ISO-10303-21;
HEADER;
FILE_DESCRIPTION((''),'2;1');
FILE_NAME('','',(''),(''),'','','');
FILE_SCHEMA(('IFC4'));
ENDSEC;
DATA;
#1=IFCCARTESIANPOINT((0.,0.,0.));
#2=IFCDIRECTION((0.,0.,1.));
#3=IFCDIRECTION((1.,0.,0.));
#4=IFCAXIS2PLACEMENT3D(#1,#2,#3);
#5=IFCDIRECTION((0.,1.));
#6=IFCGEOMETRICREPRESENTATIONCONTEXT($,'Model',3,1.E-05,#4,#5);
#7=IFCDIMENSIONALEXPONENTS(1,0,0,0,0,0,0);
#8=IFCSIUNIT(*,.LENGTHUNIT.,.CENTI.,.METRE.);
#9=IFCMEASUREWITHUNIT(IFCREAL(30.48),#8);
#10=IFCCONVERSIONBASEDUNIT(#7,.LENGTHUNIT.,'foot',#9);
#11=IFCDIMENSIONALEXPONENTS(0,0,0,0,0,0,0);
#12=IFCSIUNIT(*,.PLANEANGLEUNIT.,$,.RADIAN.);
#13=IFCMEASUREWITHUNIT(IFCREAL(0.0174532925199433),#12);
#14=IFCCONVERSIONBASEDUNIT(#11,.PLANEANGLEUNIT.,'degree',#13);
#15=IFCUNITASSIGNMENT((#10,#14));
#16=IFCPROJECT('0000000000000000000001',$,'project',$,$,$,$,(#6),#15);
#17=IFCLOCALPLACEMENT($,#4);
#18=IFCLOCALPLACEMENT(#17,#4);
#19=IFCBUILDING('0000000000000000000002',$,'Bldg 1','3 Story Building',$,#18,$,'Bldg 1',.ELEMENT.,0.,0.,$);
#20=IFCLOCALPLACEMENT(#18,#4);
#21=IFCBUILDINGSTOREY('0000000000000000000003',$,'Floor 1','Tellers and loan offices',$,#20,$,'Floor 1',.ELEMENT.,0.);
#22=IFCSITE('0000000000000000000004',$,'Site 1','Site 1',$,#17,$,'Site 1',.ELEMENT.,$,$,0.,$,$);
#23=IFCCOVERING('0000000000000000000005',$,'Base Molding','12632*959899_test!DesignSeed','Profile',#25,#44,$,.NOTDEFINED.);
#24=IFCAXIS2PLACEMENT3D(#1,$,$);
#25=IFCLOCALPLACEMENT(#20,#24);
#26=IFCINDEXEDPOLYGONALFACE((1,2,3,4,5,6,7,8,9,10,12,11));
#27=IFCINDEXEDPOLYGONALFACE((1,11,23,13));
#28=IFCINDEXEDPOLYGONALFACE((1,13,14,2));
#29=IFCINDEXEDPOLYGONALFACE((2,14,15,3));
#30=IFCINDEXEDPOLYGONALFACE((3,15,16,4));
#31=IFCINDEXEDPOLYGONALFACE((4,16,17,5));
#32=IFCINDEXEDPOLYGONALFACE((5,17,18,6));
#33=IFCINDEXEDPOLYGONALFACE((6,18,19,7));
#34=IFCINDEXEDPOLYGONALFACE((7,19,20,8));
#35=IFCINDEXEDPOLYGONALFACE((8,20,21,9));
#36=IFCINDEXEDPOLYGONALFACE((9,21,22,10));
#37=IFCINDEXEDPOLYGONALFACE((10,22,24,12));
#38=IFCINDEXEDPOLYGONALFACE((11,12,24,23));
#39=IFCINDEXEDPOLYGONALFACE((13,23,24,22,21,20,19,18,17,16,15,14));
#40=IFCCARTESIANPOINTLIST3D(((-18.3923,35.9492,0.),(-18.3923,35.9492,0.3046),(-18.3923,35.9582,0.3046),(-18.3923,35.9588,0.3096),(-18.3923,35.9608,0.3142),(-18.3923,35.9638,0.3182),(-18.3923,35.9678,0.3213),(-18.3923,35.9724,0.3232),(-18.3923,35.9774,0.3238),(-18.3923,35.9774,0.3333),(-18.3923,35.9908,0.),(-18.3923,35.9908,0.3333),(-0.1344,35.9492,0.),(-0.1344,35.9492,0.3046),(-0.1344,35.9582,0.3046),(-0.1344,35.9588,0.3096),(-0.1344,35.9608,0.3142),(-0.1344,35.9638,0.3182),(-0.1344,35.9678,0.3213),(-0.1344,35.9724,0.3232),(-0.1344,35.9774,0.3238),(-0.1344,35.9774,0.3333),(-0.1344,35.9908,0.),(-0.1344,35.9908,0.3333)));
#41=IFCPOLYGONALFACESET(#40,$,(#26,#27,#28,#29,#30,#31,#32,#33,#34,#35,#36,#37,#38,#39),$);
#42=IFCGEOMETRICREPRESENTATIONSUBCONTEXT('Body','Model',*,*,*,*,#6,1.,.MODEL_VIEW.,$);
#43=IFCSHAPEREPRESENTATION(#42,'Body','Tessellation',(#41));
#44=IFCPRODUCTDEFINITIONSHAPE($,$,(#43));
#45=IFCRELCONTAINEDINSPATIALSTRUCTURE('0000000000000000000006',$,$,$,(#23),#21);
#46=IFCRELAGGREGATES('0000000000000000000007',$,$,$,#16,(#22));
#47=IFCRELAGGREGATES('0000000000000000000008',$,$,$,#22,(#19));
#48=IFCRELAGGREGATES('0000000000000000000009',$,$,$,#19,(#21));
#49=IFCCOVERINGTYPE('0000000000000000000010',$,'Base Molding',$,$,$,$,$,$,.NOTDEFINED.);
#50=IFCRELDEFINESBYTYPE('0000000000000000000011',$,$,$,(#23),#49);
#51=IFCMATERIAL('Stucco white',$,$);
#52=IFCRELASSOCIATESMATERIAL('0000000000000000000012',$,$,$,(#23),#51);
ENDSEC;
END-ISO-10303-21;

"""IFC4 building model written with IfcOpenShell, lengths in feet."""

from ifc_helpers import new_model, entity, si_unit, converted_unit, direction, frame, origin_with_axes, place, context, subcontext, project, spatial, line, arc, indexed_curve, outline, extrude, material, type_object, element, save


model = new_model("IFC4")

# Units and contexts
model_context = context("Model", 3, precision=1e-05, world=origin_with_axes(), true_north=direction((0.0, 1.0)))
body_context = subcontext(model_context, "Body", "Model", "MODEL_VIEW", scale=1.0)
ifc_project = project(units=[converted_unit("LENGTHUNIT", "foot", entity("IfcReal", 30.48), si_unit("LENGTHUNIT", "METRE", prefix="CENTI"), dimensions=[1, 0, 0, 0, 0, 0, 0]), converted_unit("PLANEANGLEUNIT", "degree", entity("IfcReal", 0.0174532925199433), si_unit("PLANEANGLEUNIT", "RADIAN"), dimensions=[0, 0, 0, 0, 0, 0, 0])], contexts=[model_context])

# Site, building, storey
site_placement = place(None, origin_with_axes())
site = spatial("IfcSite", under=ifc_project, at=site_placement, Name="Site 1", Description="Site 1", LongName="Site 1", CompositionType="ELEMENT", RefElevation=0.0)
building_placement = place(site_placement, origin_with_axes())
building = spatial("IfcBuilding", under=site, at=building_placement, Name="Bldg 1", Description="3 Story Building", LongName="Bldg 1", CompositionType="ELEMENT", ElevationOfRefHeight=0.0, ElevationOfTerrain=0.0)
storey_placement = place(building_placement, origin_with_axes())
storey = spatial("IfcBuildingStorey", under=building, at=storey_placement, Name="Floor 1", Description="Tellers and loan offices", LongName="Floor 1", CompositionType="ELEMENT", Elevation=0.0)

# Covering
ifc_material = material(Name="Stucco white")
covering_type = type_object("IfcCoveringType", Name="Base Molding", PredefinedType="NOTDEFINED")
covering_1_placement = place(storey_placement, frame((-18.3923, 35.9774, 0.3238), z_axis=(1.0, 0.0, 0.0), x_axis=(0.0, -1.0, 0.0)))
element("IfcCovering", 1, at=covering_1_placement, inside=storey, type_object=covering_type, material=ifc_material, Name="Base Molding", Description="12632*959899_test!DesignSeed", ObjectType="Profile", PredefinedType="NOTDEFINED", context=body_context, shape_type="SweptSolid", body=[
    extrude(outline(indexed_curve([(0.0192, 0.0192), (0.0283, 0.0192), (0.0283, 0.3238), (-0.0134, 0.3238), (-0.0134, -0.0095), (0.0, -0.0095), (0.0, 0.0), (0.0136, 0.0056)], segments=[line(1, 2, 3, 4, 5, 6, 7), arc(7, 8, 1)], self_intersect=False)), origin_with_axes(), (0.0, 0.0, 1.0), 18.2579),
])

save(model, "model.ifc")
